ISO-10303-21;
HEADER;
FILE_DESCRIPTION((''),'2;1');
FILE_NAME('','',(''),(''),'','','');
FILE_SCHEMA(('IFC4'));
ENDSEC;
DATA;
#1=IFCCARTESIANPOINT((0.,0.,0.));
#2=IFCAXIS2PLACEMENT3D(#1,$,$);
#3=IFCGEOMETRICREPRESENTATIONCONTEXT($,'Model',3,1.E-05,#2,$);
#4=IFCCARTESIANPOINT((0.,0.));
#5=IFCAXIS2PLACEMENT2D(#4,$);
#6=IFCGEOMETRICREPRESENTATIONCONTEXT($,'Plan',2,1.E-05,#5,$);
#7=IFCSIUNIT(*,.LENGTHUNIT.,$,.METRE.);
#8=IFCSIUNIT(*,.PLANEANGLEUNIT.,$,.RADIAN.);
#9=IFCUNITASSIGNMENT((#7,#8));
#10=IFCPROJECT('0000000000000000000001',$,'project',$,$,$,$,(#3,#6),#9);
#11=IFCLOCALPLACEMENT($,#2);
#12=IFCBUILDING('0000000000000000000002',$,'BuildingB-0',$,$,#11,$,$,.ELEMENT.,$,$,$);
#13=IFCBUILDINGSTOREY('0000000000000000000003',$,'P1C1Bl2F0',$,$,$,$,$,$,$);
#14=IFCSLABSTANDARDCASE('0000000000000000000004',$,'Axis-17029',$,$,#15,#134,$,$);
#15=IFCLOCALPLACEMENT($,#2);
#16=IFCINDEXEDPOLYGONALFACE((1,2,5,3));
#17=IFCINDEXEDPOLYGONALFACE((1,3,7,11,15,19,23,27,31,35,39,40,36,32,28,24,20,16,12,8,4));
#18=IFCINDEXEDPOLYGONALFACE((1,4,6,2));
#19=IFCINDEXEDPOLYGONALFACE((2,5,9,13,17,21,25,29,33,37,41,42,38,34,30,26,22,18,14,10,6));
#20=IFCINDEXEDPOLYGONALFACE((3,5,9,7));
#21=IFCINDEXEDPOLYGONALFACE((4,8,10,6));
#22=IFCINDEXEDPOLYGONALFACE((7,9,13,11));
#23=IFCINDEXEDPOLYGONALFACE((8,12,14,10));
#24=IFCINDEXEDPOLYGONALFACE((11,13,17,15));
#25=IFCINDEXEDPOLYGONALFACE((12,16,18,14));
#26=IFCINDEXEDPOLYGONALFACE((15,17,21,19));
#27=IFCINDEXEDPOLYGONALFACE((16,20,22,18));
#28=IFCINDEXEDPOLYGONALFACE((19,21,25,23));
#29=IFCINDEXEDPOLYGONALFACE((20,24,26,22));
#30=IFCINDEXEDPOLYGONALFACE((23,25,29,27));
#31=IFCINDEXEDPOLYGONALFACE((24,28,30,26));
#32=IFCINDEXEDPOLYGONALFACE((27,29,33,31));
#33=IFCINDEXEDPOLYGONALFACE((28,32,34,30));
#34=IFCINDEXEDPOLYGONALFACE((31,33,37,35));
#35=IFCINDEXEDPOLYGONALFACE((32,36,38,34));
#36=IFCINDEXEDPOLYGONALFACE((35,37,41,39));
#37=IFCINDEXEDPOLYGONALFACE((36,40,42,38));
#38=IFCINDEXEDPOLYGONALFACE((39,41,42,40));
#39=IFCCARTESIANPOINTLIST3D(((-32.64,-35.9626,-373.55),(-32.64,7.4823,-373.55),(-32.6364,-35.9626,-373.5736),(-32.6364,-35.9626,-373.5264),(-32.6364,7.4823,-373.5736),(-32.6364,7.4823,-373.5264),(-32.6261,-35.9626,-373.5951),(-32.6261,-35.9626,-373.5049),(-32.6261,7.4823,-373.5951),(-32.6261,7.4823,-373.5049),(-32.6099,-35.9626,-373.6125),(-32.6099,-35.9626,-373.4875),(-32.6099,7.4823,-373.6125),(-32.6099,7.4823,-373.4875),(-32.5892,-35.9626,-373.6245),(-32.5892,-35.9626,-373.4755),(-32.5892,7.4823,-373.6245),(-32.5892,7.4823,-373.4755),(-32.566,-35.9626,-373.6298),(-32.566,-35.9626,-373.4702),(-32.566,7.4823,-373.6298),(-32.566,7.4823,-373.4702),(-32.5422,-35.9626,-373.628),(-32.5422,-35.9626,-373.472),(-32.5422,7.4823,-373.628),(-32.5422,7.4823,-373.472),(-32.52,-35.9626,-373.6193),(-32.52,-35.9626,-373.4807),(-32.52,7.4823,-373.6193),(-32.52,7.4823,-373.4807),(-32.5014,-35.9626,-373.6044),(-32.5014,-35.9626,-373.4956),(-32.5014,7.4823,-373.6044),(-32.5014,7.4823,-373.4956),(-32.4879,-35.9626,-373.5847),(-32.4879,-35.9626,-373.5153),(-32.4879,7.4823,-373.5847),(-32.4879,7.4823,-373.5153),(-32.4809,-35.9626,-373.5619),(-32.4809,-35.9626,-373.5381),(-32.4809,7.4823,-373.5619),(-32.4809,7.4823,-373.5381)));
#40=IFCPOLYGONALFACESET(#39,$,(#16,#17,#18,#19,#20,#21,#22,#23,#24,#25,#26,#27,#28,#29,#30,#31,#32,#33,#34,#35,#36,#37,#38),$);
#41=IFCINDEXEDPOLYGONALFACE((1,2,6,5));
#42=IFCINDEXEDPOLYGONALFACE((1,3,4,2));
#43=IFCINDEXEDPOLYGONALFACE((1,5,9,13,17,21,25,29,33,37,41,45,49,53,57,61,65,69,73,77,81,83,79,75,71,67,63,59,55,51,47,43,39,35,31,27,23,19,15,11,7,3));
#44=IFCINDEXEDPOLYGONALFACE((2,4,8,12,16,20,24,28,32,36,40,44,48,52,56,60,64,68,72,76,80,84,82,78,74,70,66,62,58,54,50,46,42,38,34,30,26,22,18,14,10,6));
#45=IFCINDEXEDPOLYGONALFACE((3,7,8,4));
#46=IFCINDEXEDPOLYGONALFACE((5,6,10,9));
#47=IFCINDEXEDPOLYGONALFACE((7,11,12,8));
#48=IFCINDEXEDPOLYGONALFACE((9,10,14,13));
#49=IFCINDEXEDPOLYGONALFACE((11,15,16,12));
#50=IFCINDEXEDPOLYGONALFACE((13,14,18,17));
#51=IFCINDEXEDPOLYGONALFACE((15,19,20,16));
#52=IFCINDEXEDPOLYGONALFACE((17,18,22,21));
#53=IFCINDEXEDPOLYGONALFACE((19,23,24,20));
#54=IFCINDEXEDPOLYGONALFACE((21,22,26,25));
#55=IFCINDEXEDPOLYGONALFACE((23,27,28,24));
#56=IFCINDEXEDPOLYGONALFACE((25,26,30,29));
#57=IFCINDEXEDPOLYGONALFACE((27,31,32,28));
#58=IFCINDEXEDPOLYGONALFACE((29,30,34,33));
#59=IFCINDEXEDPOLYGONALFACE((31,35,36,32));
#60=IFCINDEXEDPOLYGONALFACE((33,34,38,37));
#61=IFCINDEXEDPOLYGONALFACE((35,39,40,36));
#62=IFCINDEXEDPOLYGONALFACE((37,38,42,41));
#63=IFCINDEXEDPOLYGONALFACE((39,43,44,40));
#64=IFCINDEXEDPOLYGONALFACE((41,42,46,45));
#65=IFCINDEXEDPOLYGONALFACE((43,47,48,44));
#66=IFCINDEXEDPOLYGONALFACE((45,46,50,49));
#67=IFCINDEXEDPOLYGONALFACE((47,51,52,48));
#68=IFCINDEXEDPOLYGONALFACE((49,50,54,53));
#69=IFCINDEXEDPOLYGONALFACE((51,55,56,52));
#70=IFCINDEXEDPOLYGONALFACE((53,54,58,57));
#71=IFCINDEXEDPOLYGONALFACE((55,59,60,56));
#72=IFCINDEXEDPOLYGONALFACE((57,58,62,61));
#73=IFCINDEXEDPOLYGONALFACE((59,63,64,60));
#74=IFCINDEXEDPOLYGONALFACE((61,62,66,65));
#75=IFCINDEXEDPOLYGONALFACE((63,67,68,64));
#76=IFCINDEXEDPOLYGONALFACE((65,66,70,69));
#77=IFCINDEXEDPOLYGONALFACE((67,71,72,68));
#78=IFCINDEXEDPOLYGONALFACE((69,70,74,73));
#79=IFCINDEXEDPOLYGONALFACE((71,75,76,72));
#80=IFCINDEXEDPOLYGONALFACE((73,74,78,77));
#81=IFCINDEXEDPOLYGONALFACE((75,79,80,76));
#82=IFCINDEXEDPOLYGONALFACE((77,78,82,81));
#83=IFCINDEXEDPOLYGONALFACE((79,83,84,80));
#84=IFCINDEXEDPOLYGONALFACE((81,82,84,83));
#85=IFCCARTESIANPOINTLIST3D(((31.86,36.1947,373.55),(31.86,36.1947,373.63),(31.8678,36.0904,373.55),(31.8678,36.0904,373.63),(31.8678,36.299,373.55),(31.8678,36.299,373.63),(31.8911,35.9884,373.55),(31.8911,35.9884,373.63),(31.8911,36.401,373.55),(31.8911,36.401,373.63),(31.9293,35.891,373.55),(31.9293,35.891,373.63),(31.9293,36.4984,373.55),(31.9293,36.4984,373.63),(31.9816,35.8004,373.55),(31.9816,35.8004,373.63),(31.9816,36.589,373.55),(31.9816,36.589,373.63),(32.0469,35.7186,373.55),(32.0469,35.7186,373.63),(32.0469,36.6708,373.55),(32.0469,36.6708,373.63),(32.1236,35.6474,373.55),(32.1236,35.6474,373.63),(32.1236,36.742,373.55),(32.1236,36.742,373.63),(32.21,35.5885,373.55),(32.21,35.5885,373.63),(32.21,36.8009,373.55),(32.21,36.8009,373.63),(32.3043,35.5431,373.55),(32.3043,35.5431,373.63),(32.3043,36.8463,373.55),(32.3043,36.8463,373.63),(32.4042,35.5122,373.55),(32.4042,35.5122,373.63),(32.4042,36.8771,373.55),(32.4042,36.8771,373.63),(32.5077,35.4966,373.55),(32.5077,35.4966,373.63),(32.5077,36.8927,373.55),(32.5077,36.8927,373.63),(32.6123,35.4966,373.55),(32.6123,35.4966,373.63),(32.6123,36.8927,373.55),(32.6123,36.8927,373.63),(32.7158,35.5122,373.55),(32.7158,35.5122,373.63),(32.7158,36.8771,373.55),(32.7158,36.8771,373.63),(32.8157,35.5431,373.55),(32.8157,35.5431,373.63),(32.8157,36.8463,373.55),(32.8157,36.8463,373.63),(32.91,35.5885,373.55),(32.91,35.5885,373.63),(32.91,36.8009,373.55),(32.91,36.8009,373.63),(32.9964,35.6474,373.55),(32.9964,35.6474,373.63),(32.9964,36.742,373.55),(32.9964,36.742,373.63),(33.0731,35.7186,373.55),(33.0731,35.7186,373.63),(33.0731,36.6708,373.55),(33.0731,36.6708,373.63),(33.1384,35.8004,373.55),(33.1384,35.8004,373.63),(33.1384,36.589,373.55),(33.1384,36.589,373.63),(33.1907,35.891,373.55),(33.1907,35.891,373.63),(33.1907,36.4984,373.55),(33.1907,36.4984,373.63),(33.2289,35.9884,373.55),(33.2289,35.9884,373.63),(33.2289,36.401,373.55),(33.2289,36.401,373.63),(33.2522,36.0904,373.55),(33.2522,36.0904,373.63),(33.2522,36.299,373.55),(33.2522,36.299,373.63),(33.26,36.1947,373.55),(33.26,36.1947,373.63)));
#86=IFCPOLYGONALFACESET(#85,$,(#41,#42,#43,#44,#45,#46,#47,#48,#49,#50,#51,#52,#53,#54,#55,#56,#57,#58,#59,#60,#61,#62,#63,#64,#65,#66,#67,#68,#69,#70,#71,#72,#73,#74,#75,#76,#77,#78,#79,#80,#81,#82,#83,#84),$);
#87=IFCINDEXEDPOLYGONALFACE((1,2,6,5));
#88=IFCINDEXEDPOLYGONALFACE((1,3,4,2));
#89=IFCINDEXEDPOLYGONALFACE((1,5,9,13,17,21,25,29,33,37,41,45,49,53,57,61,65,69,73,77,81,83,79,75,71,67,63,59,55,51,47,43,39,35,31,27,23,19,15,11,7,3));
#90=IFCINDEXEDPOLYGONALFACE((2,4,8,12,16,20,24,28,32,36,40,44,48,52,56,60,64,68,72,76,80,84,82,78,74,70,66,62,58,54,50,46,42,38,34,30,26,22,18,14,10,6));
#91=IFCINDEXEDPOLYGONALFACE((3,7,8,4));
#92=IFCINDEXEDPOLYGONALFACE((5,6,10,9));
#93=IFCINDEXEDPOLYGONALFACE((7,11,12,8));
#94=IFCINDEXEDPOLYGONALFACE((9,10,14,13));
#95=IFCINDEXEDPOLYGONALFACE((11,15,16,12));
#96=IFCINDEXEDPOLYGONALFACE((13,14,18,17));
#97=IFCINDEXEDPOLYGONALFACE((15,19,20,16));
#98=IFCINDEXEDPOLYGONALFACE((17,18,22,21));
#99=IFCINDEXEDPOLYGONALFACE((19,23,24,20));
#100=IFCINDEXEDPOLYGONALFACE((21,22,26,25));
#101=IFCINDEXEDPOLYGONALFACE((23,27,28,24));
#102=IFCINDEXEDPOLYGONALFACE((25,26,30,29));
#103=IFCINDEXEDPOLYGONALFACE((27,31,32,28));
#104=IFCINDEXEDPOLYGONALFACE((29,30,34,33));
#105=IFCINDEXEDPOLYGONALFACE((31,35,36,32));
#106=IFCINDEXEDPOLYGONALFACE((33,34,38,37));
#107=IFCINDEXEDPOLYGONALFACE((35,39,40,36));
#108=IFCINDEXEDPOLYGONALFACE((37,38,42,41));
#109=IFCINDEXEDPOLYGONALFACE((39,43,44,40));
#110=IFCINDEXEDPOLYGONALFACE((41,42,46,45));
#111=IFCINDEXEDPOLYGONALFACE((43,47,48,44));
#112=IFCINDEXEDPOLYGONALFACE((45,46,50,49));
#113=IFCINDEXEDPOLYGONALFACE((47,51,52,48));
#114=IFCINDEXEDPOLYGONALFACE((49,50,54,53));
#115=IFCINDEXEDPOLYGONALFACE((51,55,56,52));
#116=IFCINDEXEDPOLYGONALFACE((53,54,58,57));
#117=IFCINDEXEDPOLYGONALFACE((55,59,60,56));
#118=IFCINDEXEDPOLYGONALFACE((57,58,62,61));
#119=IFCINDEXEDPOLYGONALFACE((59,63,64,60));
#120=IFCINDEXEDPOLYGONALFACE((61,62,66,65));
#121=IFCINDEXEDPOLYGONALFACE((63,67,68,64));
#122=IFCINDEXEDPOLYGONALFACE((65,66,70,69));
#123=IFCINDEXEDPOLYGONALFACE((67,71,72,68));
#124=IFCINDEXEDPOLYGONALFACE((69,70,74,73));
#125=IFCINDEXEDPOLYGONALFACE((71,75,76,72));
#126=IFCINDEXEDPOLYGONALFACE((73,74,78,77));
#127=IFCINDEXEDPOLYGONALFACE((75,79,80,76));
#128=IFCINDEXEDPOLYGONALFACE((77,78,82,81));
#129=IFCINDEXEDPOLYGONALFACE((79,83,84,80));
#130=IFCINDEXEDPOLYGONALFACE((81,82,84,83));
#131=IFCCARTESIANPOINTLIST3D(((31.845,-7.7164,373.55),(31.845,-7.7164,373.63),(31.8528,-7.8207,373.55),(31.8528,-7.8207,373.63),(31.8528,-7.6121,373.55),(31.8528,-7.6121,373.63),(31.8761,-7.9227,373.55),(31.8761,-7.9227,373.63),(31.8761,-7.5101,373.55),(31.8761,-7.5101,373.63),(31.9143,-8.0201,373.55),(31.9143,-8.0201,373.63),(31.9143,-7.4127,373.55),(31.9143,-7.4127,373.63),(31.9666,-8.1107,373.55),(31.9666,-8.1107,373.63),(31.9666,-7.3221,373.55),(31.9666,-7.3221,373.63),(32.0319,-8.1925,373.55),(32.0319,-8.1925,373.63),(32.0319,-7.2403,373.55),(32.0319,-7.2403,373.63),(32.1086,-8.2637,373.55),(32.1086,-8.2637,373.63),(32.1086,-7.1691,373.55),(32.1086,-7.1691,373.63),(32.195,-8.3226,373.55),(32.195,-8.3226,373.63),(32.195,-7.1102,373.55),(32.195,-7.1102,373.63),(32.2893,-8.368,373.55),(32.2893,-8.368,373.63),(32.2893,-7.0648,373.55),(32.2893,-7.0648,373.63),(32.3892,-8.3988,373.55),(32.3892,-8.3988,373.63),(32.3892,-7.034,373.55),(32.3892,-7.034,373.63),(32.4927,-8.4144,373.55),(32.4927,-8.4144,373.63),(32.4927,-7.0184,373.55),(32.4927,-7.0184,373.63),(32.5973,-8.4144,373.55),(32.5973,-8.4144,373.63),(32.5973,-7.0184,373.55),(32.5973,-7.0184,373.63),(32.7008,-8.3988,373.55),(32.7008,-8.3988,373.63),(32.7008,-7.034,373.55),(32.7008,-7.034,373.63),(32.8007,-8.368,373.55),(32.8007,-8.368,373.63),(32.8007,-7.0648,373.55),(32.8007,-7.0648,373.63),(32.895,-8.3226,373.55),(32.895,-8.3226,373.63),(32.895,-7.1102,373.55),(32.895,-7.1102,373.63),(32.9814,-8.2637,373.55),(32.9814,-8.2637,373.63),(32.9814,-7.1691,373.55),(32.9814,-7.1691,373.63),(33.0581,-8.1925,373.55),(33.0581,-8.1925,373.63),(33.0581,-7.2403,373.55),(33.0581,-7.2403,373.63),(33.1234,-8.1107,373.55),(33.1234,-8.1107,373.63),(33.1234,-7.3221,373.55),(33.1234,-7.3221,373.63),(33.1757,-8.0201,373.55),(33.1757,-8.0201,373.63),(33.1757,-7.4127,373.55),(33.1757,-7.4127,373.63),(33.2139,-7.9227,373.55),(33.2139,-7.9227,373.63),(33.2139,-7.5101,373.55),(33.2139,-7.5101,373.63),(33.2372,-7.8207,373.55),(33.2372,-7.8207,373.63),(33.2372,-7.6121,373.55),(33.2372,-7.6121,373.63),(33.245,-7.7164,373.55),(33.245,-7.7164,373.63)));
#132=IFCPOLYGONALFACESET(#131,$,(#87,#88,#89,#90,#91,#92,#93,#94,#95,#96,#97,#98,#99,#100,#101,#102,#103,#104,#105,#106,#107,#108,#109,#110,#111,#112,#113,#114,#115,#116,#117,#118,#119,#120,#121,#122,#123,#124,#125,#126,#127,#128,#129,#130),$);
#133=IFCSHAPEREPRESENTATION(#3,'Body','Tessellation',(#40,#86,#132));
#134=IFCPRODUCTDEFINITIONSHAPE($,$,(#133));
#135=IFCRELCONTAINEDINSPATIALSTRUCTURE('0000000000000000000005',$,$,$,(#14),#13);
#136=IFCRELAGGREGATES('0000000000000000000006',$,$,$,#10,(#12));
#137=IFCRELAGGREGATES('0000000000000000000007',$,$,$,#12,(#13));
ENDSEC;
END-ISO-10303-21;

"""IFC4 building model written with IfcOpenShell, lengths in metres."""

from ifc_helpers import new_model, entity, si_unit, frame, origin, origin_2d, place, context, project, spatial, circle, extrude, element, save


model = new_model("IFC4")

# Units and contexts
model_context = context("Model", 3, precision=1e-05, world=origin())
plan_context = context("Plan", 2, precision=1e-05, world=origin_2d())
ifc_project = project(units=[si_unit("LENGTHUNIT", "METRE"), si_unit("PLANEANGLEUNIT", "RADIAN")], contexts=[model_context, plan_context])

# Building, storey
building_placement = place(None, origin())
building = spatial("IfcBuilding", under=ifc_project, at=building_placement, Name="BuildingB-0", CompositionType="ELEMENT")
storey = spatial("IfcBuildingStorey", under=building, Name="P1C1Bl2F0")

# Slab
element("IfcSlabStandardCase", 1, inside=storey, Name="Axis-17029", context=model_context, shape_type="AdvancedSweptSolid", body=[
    entity("IfcSurfaceCurveSweptAreaSolid", entity("IfcCircleProfileDef", "AREA", None, None, 0.08), None, entity("IfcPolyline", [entity("IfcCartesianPoint", [32.56, 35.9626, 373.55]), entity("IfcCartesianPoint", [32.56, -7.4823, 373.55])]), None, None, entity("IfcPlane", entity("IfcAxis2Placement3D", entity("IfcCartesianPoint", [32.56, 35.9626, 373.55]), entity("IfcDirection", [0.0, 0.0, 1.0]), entity("IfcDirection", [1.0, 0.0, 0.0])))),
    extrude(circle(Radius=0.7), frame((32.56, 36.1947, 373.55)), (0.0, 0.0, 1.0), 0.08),
    extrude(circle(Radius=0.7), frame((32.545, -7.7164, 373.55)), (0.0, 0.0, 1.0), 0.08),
])

save(model, "model.ifc")
